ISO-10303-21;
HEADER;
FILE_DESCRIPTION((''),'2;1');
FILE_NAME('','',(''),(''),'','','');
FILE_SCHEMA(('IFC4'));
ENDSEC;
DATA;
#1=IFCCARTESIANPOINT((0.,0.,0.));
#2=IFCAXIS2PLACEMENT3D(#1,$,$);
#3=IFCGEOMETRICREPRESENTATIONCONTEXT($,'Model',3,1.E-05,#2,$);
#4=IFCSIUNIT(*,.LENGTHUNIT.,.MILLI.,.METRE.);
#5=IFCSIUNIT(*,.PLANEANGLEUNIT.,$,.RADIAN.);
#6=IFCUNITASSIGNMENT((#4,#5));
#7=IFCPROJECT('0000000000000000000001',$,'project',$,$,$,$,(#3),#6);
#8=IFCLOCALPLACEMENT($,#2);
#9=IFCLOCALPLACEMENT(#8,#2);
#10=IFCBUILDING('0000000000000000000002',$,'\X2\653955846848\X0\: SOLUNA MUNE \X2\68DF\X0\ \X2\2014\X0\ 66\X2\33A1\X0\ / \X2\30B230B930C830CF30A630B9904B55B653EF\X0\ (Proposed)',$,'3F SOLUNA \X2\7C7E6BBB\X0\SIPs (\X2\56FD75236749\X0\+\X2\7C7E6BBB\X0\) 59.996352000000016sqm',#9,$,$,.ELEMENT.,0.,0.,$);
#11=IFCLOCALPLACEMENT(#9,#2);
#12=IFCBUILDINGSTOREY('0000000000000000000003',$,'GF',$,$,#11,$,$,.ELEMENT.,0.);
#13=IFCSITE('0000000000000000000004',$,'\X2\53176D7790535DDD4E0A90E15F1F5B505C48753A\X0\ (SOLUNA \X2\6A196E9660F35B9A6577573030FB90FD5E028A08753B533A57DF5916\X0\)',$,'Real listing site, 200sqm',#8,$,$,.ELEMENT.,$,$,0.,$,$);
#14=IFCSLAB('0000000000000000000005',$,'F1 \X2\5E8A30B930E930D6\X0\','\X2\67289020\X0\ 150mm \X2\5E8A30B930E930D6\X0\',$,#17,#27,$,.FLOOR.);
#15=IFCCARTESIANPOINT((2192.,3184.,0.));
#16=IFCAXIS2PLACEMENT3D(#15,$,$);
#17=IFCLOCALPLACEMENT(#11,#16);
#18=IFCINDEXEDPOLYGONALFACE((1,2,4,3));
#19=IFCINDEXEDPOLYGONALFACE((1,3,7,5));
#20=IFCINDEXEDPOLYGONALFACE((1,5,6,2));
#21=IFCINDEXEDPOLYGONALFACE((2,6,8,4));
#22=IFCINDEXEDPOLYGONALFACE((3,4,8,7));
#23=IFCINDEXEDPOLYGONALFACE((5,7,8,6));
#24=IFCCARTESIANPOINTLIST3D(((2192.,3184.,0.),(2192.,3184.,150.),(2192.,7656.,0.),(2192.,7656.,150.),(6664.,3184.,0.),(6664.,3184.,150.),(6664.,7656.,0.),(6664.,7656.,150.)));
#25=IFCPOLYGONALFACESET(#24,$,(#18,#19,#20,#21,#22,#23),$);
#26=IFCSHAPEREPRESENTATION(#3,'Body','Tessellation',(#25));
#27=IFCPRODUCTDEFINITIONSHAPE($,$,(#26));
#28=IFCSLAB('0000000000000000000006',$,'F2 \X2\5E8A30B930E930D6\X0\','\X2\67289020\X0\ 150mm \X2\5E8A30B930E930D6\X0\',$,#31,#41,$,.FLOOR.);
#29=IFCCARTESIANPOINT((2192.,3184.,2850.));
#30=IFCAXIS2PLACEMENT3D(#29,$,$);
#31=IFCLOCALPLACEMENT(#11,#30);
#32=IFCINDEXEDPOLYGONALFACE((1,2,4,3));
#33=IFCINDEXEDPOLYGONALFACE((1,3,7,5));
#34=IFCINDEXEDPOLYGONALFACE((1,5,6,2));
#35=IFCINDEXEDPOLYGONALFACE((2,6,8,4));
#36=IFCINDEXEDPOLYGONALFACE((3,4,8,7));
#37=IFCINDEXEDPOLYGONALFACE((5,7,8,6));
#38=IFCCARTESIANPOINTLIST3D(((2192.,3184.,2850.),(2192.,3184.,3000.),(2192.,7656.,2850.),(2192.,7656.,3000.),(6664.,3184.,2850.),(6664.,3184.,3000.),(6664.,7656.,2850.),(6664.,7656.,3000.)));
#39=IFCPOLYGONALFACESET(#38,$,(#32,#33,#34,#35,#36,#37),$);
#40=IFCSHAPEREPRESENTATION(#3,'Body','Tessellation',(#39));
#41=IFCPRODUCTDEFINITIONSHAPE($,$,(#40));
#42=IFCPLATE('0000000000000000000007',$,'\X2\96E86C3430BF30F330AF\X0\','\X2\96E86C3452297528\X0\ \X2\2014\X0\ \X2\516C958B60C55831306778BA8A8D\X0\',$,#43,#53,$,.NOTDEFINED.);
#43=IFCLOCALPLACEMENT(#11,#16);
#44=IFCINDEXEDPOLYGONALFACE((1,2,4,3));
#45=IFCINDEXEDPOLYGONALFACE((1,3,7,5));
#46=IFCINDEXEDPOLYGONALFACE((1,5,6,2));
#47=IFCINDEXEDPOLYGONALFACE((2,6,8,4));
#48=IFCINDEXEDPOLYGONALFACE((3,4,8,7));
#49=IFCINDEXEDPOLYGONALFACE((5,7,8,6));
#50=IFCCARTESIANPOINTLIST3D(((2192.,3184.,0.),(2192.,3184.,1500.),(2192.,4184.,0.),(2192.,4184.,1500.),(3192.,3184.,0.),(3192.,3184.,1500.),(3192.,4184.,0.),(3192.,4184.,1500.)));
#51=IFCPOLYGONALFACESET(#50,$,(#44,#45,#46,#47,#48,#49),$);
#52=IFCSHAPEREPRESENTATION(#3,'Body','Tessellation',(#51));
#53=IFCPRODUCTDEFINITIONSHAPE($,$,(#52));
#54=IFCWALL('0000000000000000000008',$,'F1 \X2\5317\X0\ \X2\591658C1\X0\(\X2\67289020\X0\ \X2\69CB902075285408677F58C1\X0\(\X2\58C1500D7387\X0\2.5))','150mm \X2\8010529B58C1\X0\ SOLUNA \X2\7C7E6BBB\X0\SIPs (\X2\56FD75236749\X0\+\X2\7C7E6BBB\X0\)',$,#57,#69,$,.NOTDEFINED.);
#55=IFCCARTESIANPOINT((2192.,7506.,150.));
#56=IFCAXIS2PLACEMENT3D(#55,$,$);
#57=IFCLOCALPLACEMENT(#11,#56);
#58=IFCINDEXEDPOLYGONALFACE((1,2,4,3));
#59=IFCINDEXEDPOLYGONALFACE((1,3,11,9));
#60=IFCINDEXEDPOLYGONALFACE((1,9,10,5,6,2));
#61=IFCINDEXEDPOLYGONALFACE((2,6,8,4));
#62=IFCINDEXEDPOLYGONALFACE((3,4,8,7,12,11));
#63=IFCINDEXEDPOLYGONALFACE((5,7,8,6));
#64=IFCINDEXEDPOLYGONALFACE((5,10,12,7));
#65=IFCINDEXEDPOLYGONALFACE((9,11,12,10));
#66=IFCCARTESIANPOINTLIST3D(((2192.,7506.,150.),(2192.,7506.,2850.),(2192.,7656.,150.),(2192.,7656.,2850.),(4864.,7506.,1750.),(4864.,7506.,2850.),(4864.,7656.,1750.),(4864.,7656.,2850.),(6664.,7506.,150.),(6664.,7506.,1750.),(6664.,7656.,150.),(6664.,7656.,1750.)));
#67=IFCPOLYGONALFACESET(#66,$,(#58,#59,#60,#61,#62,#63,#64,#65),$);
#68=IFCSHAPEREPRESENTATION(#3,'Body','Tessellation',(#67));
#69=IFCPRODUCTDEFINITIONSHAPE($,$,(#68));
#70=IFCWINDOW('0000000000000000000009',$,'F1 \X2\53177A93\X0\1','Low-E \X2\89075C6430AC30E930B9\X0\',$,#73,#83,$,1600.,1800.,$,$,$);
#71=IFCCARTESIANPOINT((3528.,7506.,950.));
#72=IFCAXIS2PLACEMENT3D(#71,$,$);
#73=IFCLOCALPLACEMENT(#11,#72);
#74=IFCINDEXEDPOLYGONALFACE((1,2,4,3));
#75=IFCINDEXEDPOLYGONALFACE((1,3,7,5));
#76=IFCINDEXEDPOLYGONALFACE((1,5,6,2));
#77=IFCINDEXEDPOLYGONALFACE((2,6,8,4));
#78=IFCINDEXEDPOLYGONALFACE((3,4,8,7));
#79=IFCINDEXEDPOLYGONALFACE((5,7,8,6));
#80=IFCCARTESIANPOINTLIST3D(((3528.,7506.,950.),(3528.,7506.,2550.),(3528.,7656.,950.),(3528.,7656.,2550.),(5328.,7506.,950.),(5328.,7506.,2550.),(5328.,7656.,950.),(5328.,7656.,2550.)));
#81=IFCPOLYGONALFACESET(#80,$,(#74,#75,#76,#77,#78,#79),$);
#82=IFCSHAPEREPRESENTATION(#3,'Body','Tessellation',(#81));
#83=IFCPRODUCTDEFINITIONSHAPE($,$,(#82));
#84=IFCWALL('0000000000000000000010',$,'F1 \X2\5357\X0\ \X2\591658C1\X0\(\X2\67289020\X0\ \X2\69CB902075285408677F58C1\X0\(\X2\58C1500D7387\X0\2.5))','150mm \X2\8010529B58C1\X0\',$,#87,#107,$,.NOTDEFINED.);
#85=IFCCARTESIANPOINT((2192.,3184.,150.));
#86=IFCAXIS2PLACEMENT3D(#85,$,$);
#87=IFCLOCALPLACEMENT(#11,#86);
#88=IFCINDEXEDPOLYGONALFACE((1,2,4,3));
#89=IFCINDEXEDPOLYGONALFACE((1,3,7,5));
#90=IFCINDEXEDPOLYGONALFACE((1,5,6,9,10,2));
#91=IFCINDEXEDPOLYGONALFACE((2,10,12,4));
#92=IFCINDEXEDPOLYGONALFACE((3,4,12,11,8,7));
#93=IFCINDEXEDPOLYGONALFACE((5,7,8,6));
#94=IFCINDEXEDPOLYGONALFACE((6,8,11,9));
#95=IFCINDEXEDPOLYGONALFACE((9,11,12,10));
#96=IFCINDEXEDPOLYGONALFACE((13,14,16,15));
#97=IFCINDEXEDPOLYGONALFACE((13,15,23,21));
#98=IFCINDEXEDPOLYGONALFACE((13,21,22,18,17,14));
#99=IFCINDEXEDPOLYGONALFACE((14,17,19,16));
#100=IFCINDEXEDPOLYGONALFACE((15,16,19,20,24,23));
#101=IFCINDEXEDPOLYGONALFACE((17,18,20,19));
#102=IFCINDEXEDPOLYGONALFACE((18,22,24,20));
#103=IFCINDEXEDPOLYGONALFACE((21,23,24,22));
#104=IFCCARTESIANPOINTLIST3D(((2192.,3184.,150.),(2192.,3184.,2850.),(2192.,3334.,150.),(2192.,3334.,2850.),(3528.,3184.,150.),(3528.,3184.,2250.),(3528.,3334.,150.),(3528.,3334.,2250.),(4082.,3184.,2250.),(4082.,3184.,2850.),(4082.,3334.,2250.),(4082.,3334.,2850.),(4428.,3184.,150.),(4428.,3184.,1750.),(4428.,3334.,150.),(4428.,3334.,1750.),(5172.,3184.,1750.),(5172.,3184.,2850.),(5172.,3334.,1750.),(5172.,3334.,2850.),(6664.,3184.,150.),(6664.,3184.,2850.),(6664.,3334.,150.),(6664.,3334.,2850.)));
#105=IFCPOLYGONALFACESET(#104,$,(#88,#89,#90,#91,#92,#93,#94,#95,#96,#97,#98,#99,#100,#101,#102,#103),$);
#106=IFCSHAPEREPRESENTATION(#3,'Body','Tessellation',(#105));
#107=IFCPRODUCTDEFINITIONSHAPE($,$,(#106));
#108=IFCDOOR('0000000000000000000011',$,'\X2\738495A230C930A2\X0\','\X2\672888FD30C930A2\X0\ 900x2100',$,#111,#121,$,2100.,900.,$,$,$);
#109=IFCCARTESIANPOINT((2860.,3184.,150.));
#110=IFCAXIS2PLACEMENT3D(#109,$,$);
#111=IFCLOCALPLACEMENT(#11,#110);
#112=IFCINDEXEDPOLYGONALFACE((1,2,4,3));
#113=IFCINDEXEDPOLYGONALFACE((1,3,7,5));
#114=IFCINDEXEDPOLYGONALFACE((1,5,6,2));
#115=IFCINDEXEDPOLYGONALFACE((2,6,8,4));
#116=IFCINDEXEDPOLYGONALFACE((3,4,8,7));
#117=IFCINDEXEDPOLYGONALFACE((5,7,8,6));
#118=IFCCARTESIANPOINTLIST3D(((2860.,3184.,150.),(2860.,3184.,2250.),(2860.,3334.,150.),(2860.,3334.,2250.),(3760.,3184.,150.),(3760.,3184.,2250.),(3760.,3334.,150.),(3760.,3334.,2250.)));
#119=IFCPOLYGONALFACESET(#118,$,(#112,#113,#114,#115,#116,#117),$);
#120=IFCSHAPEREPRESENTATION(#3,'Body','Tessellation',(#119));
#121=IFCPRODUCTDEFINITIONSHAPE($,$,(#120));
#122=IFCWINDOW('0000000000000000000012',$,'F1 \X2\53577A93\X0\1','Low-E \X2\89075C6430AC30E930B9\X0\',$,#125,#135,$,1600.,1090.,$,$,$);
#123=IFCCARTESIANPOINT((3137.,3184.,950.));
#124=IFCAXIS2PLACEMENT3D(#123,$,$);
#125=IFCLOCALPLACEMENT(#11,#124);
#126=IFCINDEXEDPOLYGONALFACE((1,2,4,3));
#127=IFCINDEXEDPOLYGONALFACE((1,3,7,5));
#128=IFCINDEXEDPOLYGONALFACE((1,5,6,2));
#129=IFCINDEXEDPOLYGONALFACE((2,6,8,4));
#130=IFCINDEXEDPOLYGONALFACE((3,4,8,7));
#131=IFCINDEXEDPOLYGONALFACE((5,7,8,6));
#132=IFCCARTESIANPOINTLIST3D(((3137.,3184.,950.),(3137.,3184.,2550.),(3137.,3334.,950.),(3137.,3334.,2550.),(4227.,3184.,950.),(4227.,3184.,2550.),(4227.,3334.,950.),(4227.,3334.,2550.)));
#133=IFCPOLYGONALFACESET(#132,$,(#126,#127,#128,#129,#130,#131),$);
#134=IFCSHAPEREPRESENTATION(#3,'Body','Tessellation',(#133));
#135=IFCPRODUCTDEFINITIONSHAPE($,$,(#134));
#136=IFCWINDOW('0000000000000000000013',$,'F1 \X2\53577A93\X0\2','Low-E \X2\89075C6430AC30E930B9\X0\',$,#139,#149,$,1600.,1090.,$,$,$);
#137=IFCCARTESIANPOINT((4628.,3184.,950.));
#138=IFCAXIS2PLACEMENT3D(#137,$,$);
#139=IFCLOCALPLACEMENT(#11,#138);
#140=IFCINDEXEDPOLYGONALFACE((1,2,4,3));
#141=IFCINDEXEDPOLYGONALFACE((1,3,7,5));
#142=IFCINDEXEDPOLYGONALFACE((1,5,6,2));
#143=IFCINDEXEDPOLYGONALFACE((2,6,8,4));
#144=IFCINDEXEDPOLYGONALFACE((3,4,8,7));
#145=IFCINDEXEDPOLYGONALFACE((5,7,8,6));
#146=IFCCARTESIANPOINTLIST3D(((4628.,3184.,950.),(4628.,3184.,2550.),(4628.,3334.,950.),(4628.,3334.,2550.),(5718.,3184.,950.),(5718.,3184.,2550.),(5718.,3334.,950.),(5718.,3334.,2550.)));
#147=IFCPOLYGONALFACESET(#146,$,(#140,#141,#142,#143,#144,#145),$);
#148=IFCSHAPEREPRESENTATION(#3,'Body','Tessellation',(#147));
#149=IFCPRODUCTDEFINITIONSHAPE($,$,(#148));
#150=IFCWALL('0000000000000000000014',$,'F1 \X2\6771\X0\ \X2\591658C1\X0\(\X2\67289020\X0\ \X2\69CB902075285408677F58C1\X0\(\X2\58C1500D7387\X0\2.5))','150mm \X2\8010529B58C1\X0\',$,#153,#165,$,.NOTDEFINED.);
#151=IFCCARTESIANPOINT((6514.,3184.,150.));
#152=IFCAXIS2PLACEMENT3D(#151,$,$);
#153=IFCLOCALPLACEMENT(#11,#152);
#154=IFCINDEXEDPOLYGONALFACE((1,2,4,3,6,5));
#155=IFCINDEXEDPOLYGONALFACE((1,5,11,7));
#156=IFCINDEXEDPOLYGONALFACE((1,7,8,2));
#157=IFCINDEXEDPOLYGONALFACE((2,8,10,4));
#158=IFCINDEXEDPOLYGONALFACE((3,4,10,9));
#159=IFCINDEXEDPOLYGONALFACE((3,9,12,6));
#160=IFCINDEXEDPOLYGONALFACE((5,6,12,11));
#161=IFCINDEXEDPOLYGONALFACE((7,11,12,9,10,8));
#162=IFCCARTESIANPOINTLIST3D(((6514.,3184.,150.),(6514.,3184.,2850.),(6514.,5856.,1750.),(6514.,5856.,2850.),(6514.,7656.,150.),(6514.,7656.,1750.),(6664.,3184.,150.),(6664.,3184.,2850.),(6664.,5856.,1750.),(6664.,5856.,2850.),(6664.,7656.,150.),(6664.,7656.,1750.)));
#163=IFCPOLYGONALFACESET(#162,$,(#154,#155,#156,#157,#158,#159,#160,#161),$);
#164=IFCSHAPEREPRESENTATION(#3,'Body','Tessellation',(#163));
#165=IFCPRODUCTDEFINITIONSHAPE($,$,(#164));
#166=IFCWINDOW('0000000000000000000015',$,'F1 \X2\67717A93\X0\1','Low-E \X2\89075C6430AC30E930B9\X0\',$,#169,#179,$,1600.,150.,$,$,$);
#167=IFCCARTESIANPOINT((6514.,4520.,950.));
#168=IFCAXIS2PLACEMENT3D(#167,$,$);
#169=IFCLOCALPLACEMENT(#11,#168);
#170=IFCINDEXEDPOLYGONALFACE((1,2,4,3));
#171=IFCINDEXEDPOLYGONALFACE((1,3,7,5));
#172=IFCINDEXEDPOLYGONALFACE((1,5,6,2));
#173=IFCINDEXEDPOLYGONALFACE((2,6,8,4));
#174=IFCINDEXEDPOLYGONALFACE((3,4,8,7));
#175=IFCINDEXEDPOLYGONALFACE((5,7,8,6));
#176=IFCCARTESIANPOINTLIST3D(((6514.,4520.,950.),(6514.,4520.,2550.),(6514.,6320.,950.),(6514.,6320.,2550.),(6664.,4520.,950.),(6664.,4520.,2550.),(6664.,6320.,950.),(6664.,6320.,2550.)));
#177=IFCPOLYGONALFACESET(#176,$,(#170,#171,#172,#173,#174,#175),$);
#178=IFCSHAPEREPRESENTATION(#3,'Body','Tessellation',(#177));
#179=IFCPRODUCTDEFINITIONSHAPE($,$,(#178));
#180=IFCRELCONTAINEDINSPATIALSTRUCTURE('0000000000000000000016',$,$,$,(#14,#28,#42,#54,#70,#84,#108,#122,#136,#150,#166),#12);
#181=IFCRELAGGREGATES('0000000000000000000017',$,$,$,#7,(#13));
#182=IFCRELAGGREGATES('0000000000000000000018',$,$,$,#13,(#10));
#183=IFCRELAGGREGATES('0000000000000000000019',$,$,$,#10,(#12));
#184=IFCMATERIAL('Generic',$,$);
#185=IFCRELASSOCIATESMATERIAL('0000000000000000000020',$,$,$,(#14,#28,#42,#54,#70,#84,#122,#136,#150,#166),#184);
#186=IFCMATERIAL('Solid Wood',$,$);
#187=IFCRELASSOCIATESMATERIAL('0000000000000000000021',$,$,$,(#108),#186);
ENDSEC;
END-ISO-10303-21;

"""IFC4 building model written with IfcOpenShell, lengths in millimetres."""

from ifc_helpers import new_model, si_unit, frame, frame_2d, origin, place, context, project, spatial, rectangle, extrude, material, element, fill, save


model = new_model("IFC4")

# Units and contexts
model_context = context("Model", 3, precision=1e-05, world=origin())
ifc_project = project(units=[si_unit("LENGTHUNIT", "METRE", prefix="MILLI"), si_unit("PLANEANGLEUNIT", "RADIAN")], contexts=[model_context])

# Site, building, storey
site_placement = place(None, origin())
site = spatial("IfcSite", under=ifc_project, at=site_placement, Name="北海道川上郡弟子屈町 (SOLUNA 標準想定敷地・都市計画区域外)", ObjectType="Real listing site, 200sqm", CompositionType="ELEMENT", RefElevation=0.0)
building_placement = place(site_placement, origin())
building = spatial("IfcBuilding", under=site, at=building_placement, Name="改善案: SOLUNA MUNE 棟 — 66㎡ / ゲストハウス運営可 (Proposed)", ObjectType="3F SOLUNA 籾殻SIPs (国産杉+籾殻) 59.996352000000016sqm", CompositionType="ELEMENT", ElevationOfRefHeight=0.0, ElevationOfTerrain=0.0)
storey_placement = place(building_placement, origin())
storey = spatial("IfcBuildingStorey", under=building, at=storey_placement, Name="GF", CompositionType="ELEMENT", Elevation=0.0)

# Slabs
ifc_material_1 = material(Name="Generic")
slab_1_placement = place(storey_placement, frame((2192.0, 3184.0, 0.0)))
element("IfcSlab", 1, at=slab_1_placement, inside=storey, material=ifc_material_1, Name="F1 床スラブ", Description="木造 150mm 床スラブ", PredefinedType="FLOOR", context=model_context, shape_type="SweptSolid", body=[
    extrude(rectangle(XDim=4472.0, YDim=4472.0, at=frame_2d((2236.0, 2236.0))), frame((2192.0, 3184.0, 0.0)), (0.0, 0.0, 1.0), 150.0),
])
slab_2_placement = place(storey_placement, frame((2192.0, 3184.0, 2850.0)))
element("IfcSlab", 2, at=slab_2_placement, inside=storey, material=ifc_material_1, Name="F2 床スラブ", Description="木造 150mm 床スラブ", PredefinedType="FLOOR", context=model_context, shape_type="SweptSolid", body=[
    extrude(rectangle(XDim=4472.0, YDim=4472.0, at=frame_2d((2236.0, 2236.0))), frame((2192.0, 3184.0, 2850.0)), (0.0, 0.0, 1.0), 150.0),
])

# Plate
plate_placement = place(storey_placement, frame((2192.0, 3184.0, 0.0)))
element("IfcPlate", 3, at=plate_placement, inside=storey, material=ifc_material_1, Name="雨水タンク", Description="雨水利用 — 公開情報で確認", PredefinedType="NOTDEFINED", context=model_context, shape_type="SweptSolid", body=[
    extrude(rectangle(XDim=1000.0, YDim=1000.0, at=frame_2d((500.0, 500.0))), frame((2192.0, 3184.0, 0.0)), (0.0, 0.0, 1.0), 1500.0),
])

# Wall, opening, window
wall_1_placement = place(storey_placement, frame((2192.0, 7506.0, 150.0)))
wall_1 = element("IfcWall", 4, at=wall_1_placement, inside=storey, material=ifc_material_1, Name="F1 北 外壁(木造 構造用合板壁(壁倍率2.5))", Description="150mm 耐力壁 SOLUNA 籾殻SIPs (国産杉+籾殻)", PredefinedType="NOTDEFINED", context=model_context, shape_type="SweptSolid", body=[
    extrude(rectangle(XDim=4472.0, YDim=150.0, at=frame_2d((2236.0, 75.0))), frame((2192.0, 7506.0, 150.0)), (0.0, 0.0, 1.0), 2700.0),
])
opening_1_placement = place(storey_placement, frame((3528.0, 7506.0, 950.0)))
opening_1 = element("IfcOpeningElement", 5, at=opening_1_placement, cuts=wall_1, PredefinedType="NOTDEFINED", context=model_context, shape_type="SweptSolid", body=[
    extrude(rectangle(XDim=1800.0, YDim=150.0, at=frame_2d((900.0, 75.0))), frame((3528.0, 7506.0, 950.0)), (0.0, 0.0, 1.0), 1600.0),
])
window_1_placement = place(storey_placement, frame((3528.0, 7506.0, 950.0)))
window_1 = element("IfcWindow", 6, at=window_1_placement, inside=storey, material=ifc_material_1, Name="F1 北窓1", Description="Low-E 複層ガラス", OverallHeight=1600.0, OverallWidth=1800.0, context=model_context, shape_type="SweptSolid", body=[
    extrude(rectangle(XDim=1800.0, YDim=150.0, at=frame_2d((900.0, 75.0))), frame((3528.0, 7506.0, 950.0)), (0.0, 0.0, 1.0), 1600.0),
])
fill(opening_1, window_1)

# Wall, openings, door, windows
wall_2_placement = place(storey_placement, frame((2192.0, 3184.0, 150.0)))
wall_2 = element("IfcWall", 7, at=wall_2_placement, inside=storey, material=ifc_material_1, Name="F1 南 外壁(木造 構造用合板壁(壁倍率2.5))", Description="150mm 耐力壁", PredefinedType="NOTDEFINED", context=model_context, shape_type="SweptSolid", body=[
    extrude(rectangle(XDim=4472.0, YDim=150.0, at=frame_2d((2236.0, 75.0))), frame((2192.0, 3184.0, 150.0)), (0.0, 0.0, 1.0), 2700.0),
])
opening_2_placement = place(storey_placement, frame((2860.0, 3184.0, 150.0)))
opening_2 = element("IfcOpeningElement", 8, at=opening_2_placement, cuts=wall_2, PredefinedType="NOTDEFINED", context=model_context, shape_type="SweptSolid", body=[
    extrude(rectangle(XDim=900.0, YDim=150.0, at=frame_2d((450.0, 75.0))), frame((2860.0, 3184.0, 150.0)), (0.0, 0.0, 1.0), 2100.0),
])
opening_3_placement = place(storey_placement, frame((3137.0, 3184.0, 950.0)))
opening_3 = element("IfcOpeningElement", 9, at=opening_3_placement, cuts=wall_2, PredefinedType="NOTDEFINED", context=model_context, shape_type="SweptSolid", body=[
    extrude(rectangle(XDim=1090.0, YDim=150.0, at=frame_2d((545.0, 75.0))), frame((3137.0, 3184.0, 950.0)), (0.0, 0.0, 1.0), 1600.0),
])
opening_4_placement = place(storey_placement, frame((4628.0, 3184.0, 950.0)))
opening_4 = element("IfcOpeningElement", 10, at=opening_4_placement, cuts=wall_2, PredefinedType="NOTDEFINED", context=model_context, shape_type="SweptSolid", body=[
    extrude(rectangle(XDim=1090.0, YDim=150.0, at=frame_2d((545.0, 75.0))), frame((4628.0, 3184.0, 950.0)), (0.0, 0.0, 1.0), 1600.0),
])
ifc_material_2 = material(Name="Solid Wood")
door_placement = place(storey_placement, frame((2860.0, 3184.0, 150.0)))
door = element("IfcDoor", 11, at=door_placement, inside=storey, material=ifc_material_2, Name="玄関ドア", Description="木製ドア 900x2100", OverallHeight=2100.0, OverallWidth=900.0, context=model_context, shape_type="SweptSolid", body=[
    extrude(rectangle(XDim=900.0, YDim=150.0, at=frame_2d((450.0, 75.0))), frame((2860.0, 3184.0, 150.0)), (0.0, 0.0, 1.0), 2100.0),
])
fill(opening_2, door)
window_2_placement = place(storey_placement, frame((3137.0, 3184.0, 950.0)))
window_2 = element("IfcWindow", 12, at=window_2_placement, inside=storey, material=ifc_material_1, Name="F1 南窓1", Description="Low-E 複層ガラス", OverallHeight=1600.0, OverallWidth=1090.0, context=model_context, shape_type="SweptSolid", body=[
    extrude(rectangle(XDim=1090.0, YDim=150.0, at=frame_2d((545.0, 75.0))), frame((3137.0, 3184.0, 950.0)), (0.0, 0.0, 1.0), 1600.0),
])
fill(opening_3, window_2)
window_3_placement = place(storey_placement, frame((4628.0, 3184.0, 950.0)))
window_3 = element("IfcWindow", 13, at=window_3_placement, inside=storey, material=ifc_material_1, Name="F1 南窓2", Description="Low-E 複層ガラス", OverallHeight=1600.0, OverallWidth=1090.0, context=model_context, shape_type="SweptSolid", body=[
    extrude(rectangle(XDim=1090.0, YDim=150.0, at=frame_2d((545.0, 75.0))), frame((4628.0, 3184.0, 950.0)), (0.0, 0.0, 1.0), 1600.0),
])
fill(opening_4, window_3)

# Wall, opening, window
wall_3_placement = place(storey_placement, frame((6514.0, 3184.0, 150.0)))
wall_3 = element("IfcWall", 14, at=wall_3_placement, inside=storey, material=ifc_material_1, Name="F1 東 外壁(木造 構造用合板壁(壁倍率2.5))", Description="150mm 耐力壁", PredefinedType="NOTDEFINED", context=model_context, shape_type="SweptSolid", body=[
    extrude(rectangle(XDim=150.0, YDim=4472.0, at=frame_2d((75.0, 2236.0))), frame((6514.0, 3184.0, 150.0)), (0.0, 0.0, 1.0), 2700.0),
])
opening_5_placement = place(storey_placement, frame((6514.0, 4520.0, 950.0)))
opening_5 = element("IfcOpeningElement", 15, at=opening_5_placement, cuts=wall_3, PredefinedType="NOTDEFINED", context=model_context, shape_type="SweptSolid", body=[
    extrude(rectangle(XDim=150.0, YDim=1800.0, at=frame_2d((75.0, 900.0))), frame((6514.0, 4520.0, 950.0)), (0.0, 0.0, 1.0), 1600.0),
])
window_4_placement = place(storey_placement, frame((6514.0, 4520.0, 950.0)))
window_4 = element("IfcWindow", 16, at=window_4_placement, inside=storey, material=ifc_material_1, Name="F1 東窓1", Description="Low-E 複層ガラス", OverallHeight=1600.0, OverallWidth=150.0, context=model_context, shape_type="SweptSolid", body=[
    extrude(rectangle(XDim=150.0, YDim=1800.0, at=frame_2d((75.0, 900.0))), frame((6514.0, 4520.0, 950.0)), (0.0, 0.0, 1.0), 1600.0),
])
fill(opening_5, window_4)

save(model, "model.ifc")
